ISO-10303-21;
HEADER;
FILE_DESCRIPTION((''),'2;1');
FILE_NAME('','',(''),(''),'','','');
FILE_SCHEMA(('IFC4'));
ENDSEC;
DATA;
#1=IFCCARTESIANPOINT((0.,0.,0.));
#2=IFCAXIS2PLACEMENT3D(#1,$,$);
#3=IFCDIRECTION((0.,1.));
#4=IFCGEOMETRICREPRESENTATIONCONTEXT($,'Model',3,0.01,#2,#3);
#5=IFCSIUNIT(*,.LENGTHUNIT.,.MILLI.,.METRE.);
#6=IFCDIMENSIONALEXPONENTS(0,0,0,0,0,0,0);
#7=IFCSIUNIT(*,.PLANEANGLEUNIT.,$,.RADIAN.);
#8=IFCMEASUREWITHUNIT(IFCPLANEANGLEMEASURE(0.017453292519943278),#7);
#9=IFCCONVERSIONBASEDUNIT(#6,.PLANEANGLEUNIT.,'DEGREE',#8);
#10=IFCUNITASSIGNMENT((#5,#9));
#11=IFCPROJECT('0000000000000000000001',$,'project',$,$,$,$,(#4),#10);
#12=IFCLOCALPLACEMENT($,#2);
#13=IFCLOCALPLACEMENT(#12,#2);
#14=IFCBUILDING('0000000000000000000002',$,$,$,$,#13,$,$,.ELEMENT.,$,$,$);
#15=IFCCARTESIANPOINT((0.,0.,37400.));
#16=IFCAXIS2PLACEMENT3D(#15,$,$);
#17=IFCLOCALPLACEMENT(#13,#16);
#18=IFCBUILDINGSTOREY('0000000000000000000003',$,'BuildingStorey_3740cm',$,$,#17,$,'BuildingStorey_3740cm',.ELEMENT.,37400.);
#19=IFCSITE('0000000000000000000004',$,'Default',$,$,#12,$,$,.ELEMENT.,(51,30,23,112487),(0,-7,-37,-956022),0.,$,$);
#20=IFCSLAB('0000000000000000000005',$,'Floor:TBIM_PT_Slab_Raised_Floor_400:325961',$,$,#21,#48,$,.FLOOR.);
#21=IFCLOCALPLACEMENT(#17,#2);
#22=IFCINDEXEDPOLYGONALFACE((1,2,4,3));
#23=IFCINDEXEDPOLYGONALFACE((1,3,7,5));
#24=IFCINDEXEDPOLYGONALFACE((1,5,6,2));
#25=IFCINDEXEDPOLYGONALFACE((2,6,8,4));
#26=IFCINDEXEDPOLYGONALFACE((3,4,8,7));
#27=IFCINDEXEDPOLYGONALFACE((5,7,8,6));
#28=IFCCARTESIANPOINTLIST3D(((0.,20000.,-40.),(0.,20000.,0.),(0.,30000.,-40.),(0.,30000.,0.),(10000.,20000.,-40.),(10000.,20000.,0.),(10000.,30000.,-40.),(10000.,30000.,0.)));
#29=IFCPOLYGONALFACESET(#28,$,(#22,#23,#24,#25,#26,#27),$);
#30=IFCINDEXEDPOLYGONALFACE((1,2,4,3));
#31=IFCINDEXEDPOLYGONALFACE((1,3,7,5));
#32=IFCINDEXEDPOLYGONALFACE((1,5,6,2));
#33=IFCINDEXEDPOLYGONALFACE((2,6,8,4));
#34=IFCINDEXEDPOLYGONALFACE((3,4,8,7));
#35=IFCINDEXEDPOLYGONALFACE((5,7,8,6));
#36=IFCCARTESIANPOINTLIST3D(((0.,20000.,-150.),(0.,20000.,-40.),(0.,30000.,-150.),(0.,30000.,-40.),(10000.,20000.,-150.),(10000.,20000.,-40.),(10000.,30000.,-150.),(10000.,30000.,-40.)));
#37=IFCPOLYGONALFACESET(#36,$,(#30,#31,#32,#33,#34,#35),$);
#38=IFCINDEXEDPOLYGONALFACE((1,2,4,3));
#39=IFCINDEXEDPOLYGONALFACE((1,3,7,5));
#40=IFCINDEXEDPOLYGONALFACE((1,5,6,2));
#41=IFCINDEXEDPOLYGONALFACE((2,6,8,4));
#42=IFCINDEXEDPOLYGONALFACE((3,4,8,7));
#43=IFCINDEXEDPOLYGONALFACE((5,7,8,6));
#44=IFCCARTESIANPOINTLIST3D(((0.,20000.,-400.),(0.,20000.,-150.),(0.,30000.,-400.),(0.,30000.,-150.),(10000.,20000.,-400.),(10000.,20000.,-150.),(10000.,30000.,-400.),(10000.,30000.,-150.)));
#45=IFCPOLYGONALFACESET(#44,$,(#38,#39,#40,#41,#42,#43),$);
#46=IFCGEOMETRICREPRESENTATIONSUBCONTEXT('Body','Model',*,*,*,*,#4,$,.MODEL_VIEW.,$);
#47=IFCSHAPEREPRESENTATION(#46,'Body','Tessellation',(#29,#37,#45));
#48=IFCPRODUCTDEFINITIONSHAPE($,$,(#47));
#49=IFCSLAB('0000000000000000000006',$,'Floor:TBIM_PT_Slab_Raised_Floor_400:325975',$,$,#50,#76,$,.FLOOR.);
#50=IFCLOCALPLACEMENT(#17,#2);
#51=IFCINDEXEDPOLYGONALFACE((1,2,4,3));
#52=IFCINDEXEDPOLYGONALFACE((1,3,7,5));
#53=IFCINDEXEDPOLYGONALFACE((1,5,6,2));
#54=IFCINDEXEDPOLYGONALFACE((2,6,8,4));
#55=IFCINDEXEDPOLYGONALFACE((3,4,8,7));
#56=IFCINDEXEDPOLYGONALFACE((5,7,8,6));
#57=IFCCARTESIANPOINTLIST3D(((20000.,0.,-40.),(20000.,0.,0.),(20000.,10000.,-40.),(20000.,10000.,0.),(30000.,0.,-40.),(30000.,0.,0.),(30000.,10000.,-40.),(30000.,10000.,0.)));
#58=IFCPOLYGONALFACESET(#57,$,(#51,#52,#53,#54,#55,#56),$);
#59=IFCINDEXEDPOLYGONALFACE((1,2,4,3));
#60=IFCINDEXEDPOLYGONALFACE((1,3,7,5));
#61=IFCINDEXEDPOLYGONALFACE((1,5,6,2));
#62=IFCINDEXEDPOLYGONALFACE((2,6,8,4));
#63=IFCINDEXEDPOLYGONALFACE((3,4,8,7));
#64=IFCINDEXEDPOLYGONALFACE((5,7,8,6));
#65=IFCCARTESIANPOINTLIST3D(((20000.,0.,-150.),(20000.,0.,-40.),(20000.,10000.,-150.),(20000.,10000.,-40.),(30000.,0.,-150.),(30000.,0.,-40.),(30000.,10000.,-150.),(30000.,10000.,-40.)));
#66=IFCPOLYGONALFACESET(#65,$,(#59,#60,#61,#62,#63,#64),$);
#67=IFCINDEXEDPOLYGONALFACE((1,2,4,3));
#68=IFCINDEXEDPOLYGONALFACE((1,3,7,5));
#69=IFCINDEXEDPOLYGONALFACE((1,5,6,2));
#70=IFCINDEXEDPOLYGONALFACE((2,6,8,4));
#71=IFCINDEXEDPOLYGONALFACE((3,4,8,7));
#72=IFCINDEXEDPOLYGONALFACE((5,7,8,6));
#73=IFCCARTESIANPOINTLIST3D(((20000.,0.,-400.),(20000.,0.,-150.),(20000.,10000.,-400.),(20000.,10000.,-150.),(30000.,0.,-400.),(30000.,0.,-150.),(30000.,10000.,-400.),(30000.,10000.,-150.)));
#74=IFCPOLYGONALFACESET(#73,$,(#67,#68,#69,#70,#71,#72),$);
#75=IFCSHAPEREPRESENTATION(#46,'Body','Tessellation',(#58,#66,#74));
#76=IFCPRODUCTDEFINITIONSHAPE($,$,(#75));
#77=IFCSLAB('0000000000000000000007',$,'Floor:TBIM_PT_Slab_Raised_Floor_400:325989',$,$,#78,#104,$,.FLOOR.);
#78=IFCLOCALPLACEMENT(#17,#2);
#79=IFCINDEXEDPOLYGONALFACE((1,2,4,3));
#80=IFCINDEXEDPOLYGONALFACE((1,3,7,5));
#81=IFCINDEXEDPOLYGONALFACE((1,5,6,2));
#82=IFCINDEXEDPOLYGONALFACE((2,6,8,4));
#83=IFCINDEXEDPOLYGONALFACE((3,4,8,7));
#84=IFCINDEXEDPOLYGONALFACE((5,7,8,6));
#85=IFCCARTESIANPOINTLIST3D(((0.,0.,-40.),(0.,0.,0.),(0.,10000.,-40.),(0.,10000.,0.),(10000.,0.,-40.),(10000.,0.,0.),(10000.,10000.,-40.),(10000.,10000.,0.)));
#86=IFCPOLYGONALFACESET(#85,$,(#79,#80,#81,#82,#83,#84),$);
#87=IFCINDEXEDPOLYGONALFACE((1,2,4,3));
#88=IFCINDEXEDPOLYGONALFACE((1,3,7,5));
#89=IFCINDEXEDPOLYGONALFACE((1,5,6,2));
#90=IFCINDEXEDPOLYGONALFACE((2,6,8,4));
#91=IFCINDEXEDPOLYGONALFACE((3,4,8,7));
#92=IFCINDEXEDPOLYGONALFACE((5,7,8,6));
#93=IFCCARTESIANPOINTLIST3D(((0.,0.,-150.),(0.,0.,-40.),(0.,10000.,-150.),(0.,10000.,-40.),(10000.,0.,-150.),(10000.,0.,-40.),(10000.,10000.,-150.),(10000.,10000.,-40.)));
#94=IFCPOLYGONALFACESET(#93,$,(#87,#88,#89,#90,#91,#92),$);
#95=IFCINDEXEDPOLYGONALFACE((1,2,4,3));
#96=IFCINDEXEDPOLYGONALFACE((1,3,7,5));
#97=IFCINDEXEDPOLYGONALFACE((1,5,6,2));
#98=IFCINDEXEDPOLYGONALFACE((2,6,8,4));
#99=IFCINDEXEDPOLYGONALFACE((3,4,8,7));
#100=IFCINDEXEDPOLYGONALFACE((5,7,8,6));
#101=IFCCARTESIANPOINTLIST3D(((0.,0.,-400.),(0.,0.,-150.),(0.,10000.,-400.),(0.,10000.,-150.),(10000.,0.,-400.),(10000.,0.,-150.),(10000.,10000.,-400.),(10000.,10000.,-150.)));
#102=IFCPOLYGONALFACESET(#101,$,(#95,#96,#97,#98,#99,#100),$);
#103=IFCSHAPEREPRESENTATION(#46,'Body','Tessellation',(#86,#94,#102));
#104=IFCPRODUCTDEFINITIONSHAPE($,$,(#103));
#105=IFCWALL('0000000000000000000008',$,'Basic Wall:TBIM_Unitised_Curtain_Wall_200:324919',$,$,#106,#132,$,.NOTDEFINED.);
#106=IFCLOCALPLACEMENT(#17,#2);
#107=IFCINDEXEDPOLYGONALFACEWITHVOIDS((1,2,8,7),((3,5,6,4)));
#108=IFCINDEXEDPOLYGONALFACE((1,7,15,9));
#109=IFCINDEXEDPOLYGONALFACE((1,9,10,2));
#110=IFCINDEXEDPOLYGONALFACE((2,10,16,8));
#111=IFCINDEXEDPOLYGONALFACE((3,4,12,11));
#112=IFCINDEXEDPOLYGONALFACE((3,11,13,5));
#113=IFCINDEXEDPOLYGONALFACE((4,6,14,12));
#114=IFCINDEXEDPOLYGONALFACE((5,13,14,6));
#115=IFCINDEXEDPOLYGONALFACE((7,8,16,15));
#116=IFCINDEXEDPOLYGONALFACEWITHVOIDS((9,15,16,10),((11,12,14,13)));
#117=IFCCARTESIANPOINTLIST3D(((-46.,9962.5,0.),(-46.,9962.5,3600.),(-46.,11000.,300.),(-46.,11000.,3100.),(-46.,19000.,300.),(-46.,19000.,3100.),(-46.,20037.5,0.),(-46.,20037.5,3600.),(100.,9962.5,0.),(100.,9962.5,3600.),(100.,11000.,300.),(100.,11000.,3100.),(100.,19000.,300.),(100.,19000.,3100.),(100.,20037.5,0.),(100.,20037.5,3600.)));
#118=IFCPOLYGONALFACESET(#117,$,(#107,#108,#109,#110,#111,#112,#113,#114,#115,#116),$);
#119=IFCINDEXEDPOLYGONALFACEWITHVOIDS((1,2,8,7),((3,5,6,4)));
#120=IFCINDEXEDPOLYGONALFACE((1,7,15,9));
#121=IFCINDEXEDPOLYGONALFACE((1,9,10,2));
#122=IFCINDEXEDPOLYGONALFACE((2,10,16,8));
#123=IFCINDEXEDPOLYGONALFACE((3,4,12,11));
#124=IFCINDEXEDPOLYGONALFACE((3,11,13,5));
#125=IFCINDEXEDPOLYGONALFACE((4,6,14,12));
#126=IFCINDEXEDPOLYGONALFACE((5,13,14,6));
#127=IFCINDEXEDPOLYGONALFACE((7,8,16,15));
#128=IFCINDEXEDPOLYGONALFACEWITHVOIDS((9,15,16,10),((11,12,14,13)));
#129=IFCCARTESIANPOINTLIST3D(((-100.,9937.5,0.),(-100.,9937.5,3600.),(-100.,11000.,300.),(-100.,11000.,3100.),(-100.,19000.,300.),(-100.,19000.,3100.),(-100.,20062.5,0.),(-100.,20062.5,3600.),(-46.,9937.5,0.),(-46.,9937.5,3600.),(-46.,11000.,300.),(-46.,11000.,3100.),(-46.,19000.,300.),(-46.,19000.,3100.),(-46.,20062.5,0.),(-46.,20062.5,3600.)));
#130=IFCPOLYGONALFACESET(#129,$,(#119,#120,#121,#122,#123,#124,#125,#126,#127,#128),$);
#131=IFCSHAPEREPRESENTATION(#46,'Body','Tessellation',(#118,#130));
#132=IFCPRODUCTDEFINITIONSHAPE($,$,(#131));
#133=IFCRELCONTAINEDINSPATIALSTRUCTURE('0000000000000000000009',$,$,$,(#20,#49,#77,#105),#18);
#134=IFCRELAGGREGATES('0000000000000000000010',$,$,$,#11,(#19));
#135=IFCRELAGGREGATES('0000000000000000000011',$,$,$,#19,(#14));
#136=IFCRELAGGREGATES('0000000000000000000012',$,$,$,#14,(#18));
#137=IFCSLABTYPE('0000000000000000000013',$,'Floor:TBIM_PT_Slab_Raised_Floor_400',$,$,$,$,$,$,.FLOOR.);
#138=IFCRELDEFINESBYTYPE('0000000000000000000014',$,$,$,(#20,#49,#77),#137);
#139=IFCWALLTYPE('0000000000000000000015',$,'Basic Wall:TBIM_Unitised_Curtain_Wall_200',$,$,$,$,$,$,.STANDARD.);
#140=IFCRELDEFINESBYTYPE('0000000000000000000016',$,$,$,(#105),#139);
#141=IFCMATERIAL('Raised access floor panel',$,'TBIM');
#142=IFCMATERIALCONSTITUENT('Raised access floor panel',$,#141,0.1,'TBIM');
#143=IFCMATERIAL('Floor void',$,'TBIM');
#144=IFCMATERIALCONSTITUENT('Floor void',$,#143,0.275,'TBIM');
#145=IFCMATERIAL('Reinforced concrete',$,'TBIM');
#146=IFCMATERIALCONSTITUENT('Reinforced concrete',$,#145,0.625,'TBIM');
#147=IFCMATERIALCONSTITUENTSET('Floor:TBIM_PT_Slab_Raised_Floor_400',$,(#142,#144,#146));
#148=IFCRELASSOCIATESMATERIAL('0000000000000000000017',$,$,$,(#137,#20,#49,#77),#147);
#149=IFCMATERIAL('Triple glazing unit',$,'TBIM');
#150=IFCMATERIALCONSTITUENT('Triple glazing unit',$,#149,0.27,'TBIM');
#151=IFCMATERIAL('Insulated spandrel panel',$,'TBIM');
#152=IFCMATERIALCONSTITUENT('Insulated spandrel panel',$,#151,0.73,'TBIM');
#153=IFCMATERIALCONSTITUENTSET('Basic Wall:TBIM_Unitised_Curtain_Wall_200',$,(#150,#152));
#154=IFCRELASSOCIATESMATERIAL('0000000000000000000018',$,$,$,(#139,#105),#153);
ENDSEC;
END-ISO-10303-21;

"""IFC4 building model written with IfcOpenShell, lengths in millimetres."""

from ifc_helpers import new_model, entity, si_unit, converted_unit, direction, frame, origin, place, context, subcontext, project, spatial, indexed_curve, outline, extrude, material, constituent, constituent_set, type_object, element, save


model = new_model("IFC4")

# Units and contexts
model_context = context("Model", 3, precision=0.01, world=origin(), true_north=direction((0.0, 1.0)))
body_context = subcontext(model_context, "Body", "Model", "MODEL_VIEW")
ifc_project = project(units=[si_unit("LENGTHUNIT", "METRE", prefix="MILLI"), converted_unit("PLANEANGLEUNIT", "DEGREE", entity("IfcPlaneAngleMeasure", 0.017453292519943278), si_unit("PLANEANGLEUNIT", "RADIAN"), dimensions=[0, 0, 0, 0, 0, 0, 0])], contexts=[model_context])

# Site, building, storey
site_placement = place(None, origin())
site = spatial("IfcSite", under=ifc_project, at=site_placement, Name="Default", CompositionType="ELEMENT", RefLatitude=(51, 30, 23, 112487), RefLongitude=(0, -7, -37, -956022), RefElevation=0.0)
building_placement = place(site_placement, origin())
building = spatial("IfcBuilding", under=site, at=building_placement, CompositionType="ELEMENT")
storey_placement = place(building_placement, frame((0.0, 0.0, 37400.0)))
storey = spatial("IfcBuildingStorey", under=building, at=storey_placement, Name="BuildingStorey_3740cm", LongName="BuildingStorey_3740cm", CompositionType="ELEMENT", Elevation=37400.0)

# Slabs
ifc_material_1 = material(Name="Raised access floor panel", Category="TBIM")
ifc_constituent_1 = constituent(ifc_material_1, Name="Raised access floor panel", Category="TBIM", fraction=0.1)
ifc_material_2 = material(Name="Floor void", Category="TBIM")
ifc_constituent_2 = constituent(ifc_material_2, Name="Floor void", Category="TBIM", fraction=0.275)
ifc_material_3 = material(Name="Reinforced concrete", Category="TBIM")
ifc_constituent_3 = constituent(ifc_material_3, Name="Reinforced concrete", Category="TBIM", fraction=0.625)
ifc_constituent_set_1 = constituent_set(constituents=[ifc_constituent_1, ifc_constituent_2, ifc_constituent_3], Name="Floor:TBIM_PT_Slab_Raised_Floor_400")
slab_type = type_object("IfcSlabType", Name="Floor:TBIM_PT_Slab_Raised_Floor_400", PredefinedType="FLOOR", material=ifc_constituent_set_1)
slab_1_placement = place(storey_placement, origin())
element("IfcSlab", 1, at=slab_1_placement, inside=storey, type_object=slab_type, material=ifc_constituent_set_1, Name="Floor:TBIM_PT_Slab_Raised_Floor_400:325961", PredefinedType="FLOOR", context=body_context, shape_type="SweptSolid", body=[
    extrude(outline(indexed_curve([(-5000.0, -5000.0), (5000.0, -5000.0), (5000.0, 5000.0), (-5000.0, 5000.0), (-5000.0, -5000.0)], self_intersect=False)), frame((5000.0, 25000.0, -40.0), z_axis=(0.0, 0.0, 1.0), x_axis=(-1.0, 0.0, 0.0)), (0.0, 0.0, 1.0), 40.0),
    extrude(outline(indexed_curve([(-5000.0, -5000.0), (5000.0, -5000.0), (5000.0, 5000.0), (-5000.0, 5000.0), (-5000.0, -5000.0)], self_intersect=False)), frame((5000.0, 25000.0, -150.0), z_axis=(0.0, 0.0, 1.0), x_axis=(-1.0, 0.0, 0.0)), (0.0, 0.0, 1.0), 110.0),
    extrude(outline(indexed_curve([(-5000.0, -5000.0), (5000.0, -5000.0), (5000.0, 5000.0), (-5000.0, 5000.0), (-5000.0, -5000.0)], self_intersect=False)), frame((5000.0, 25000.0, -400.0), z_axis=(0.0, 0.0, 1.0), x_axis=(-1.0, 0.0, 0.0)), (0.0, 0.0, 1.0), 250.0),
])
slab_2_placement = place(storey_placement, origin())
element("IfcSlab", 2, at=slab_2_placement, inside=storey, type_object=slab_type, material=ifc_constituent_set_1, Name="Floor:TBIM_PT_Slab_Raised_Floor_400:325975", PredefinedType="FLOOR", context=body_context, shape_type="SweptSolid", body=[
    extrude(outline(indexed_curve([(-5000.0, -5000.0), (5000.0, -5000.0), (5000.0, 5000.0), (-5000.0, 5000.0), (-5000.0, -5000.0)], self_intersect=False)), frame((25000.0, 5000.0, -40.0), z_axis=(0.0, 0.0, 1.0), x_axis=(-1.0, 0.0, 0.0)), (0.0, 0.0, 1.0), 40.0),
    extrude(outline(indexed_curve([(-5000.0, -5000.0), (5000.0, -5000.0), (5000.0, 5000.0), (-5000.0, 5000.0), (-5000.0, -5000.0)], self_intersect=False)), frame((25000.0, 5000.0, -150.0), z_axis=(0.0, 0.0, 1.0), x_axis=(-1.0, 0.0, 0.0)), (0.0, 0.0, 1.0), 110.0),
    extrude(outline(indexed_curve([(-5000.0, -5000.0), (5000.0, -5000.0), (5000.0, 5000.0), (-5000.0, 5000.0), (-5000.0, -5000.0)], self_intersect=False)), frame((25000.0, 5000.0, -400.0), z_axis=(0.0, 0.0, 1.0), x_axis=(-1.0, 0.0, 0.0)), (0.0, 0.0, 1.0), 250.0),
])
slab_3_placement = place(storey_placement, origin())
element("IfcSlab", 3, at=slab_3_placement, inside=storey, type_object=slab_type, material=ifc_constituent_set_1, Name="Floor:TBIM_PT_Slab_Raised_Floor_400:325989", PredefinedType="FLOOR", context=body_context, shape_type="SweptSolid", body=[
    extrude(outline(indexed_curve([(-5000.0, -5000.0), (5000.0, -5000.0), (5000.0, 5000.0), (-5000.0, 5000.0), (-5000.0, -5000.0)], self_intersect=False)), frame((5000.0, 5000.0, -40.0), z_axis=(0.0, 0.0, 1.0), x_axis=(-1.0, 0.0, 0.0)), (0.0, 0.0, 1.0), 40.0),
    extrude(outline(indexed_curve([(-5000.0, -5000.0), (5000.0, -5000.0), (5000.0, 5000.0), (-5000.0, 5000.0), (-5000.0, -5000.0)], self_intersect=False)), frame((5000.0, 5000.0, -150.0), z_axis=(0.0, 0.0, 1.0), x_axis=(-1.0, 0.0, 0.0)), (0.0, 0.0, 1.0), 110.0),
    extrude(outline(indexed_curve([(-5000.0, -5000.0), (5000.0, -5000.0), (5000.0, 5000.0), (-5000.0, 5000.0), (-5000.0, -5000.0)], self_intersect=False)), frame((5000.0, 5000.0, -400.0), z_axis=(0.0, 0.0, 1.0), x_axis=(-1.0, 0.0, 0.0)), (0.0, 0.0, 1.0), 250.0),
])

# Wall, opening
ifc_material_4 = material(Name="Triple glazing unit", Category="TBIM")
ifc_constituent_4 = constituent(ifc_material_4, Name="Triple glazing unit", Category="TBIM", fraction=0.27)
ifc_material_5 = material(Name="Insulated spandrel panel", Category="TBIM")
ifc_constituent_5 = constituent(ifc_material_5, Name="Insulated spandrel panel", Category="TBIM", fraction=0.73)
ifc_constituent_set_2 = constituent_set(constituents=[ifc_constituent_4, ifc_constituent_5], Name="Basic Wall:TBIM_Unitised_Curtain_Wall_200")
wall_type = type_object("IfcWallType", Name="Basic Wall:TBIM_Unitised_Curtain_Wall_200", PredefinedType="STANDARD", material=ifc_constituent_set_2)
wall_1_placement = place(storey_placement, frame((0.0, 9937.5, 0.0), z_axis=(0.0, 0.0, 1.0), x_axis=(0.0, 1.0, 0.0)))
wall_1 = element("IfcWall", 4, at=wall_1_placement, inside=storey, type_object=wall_type, material=ifc_constituent_set_2, Name="Basic Wall:TBIM_Unitised_Curtain_Wall_200:324919", PredefinedType="NOTDEFINED", context=body_context, shape_type="SweptSolid", body=[
    extrude(outline(indexed_curve([(-1800.0, -5037.5), (1800.0, -5037.5), (1800.0, 5037.5), (-1800.0, 5037.5), (-1800.0, -5037.5)], self_intersect=False), holes=[indexed_curve([(1300.0, 4000.0), (1300.0, -4000.0), (-1500.0, -4000.0), (-1500.0, 4000.0), (1300.0, 4000.0)], self_intersect=False)]), frame((5062.5, 46.0, 1800.0), z_axis=(0.0, -1.0, 0.0), x_axis=(0.0, 0.0, 1.0)), (0.0, 0.0, 1.0), 146.0),
    extrude(outline(indexed_curve([(-5062.5, -1800.0), (5062.5, -1800.0), (5062.5, 1800.0), (-5062.5, 1800.0), (-5062.5, -1800.0)], self_intersect=False), holes=[indexed_curve([(-4000.0, 1300.0), (4000.0, 1300.0), (4000.0, -1500.0), (-4000.0, -1500.0), (-4000.0, 1300.0)], self_intersect=False)]), frame((5062.5, 100.0, 1800.0), z_axis=(0.0, -1.0, 0.0), x_axis=(1.0, 0.0, 0.0)), (0.0, 0.0, 1.0), 54.0),
])
opening_1_placement = place(wall_1_placement, frame((1062.5, -100.0, 300.0)))
element("IfcOpeningElement", 5, at=opening_1_placement, cuts=wall_1, PredefinedType="OPENING", context=body_context, shape_type="SweptSolid", body=[
    extrude(outline(indexed_curve([(2800.0, 0.0), (2800.0, 8000.0), (0.0, 8000.0), (0.0, 0.0), (2800.0, 0.0)], self_intersect=False)), frame((0.0, 0.0, 0.0), z_axis=(0.0, 1.0, 0.0), x_axis=(0.0, 0.0, 1.0)), (0.0, 0.0, 1.0), 200.0),
])

save(model, "model.ifc")
